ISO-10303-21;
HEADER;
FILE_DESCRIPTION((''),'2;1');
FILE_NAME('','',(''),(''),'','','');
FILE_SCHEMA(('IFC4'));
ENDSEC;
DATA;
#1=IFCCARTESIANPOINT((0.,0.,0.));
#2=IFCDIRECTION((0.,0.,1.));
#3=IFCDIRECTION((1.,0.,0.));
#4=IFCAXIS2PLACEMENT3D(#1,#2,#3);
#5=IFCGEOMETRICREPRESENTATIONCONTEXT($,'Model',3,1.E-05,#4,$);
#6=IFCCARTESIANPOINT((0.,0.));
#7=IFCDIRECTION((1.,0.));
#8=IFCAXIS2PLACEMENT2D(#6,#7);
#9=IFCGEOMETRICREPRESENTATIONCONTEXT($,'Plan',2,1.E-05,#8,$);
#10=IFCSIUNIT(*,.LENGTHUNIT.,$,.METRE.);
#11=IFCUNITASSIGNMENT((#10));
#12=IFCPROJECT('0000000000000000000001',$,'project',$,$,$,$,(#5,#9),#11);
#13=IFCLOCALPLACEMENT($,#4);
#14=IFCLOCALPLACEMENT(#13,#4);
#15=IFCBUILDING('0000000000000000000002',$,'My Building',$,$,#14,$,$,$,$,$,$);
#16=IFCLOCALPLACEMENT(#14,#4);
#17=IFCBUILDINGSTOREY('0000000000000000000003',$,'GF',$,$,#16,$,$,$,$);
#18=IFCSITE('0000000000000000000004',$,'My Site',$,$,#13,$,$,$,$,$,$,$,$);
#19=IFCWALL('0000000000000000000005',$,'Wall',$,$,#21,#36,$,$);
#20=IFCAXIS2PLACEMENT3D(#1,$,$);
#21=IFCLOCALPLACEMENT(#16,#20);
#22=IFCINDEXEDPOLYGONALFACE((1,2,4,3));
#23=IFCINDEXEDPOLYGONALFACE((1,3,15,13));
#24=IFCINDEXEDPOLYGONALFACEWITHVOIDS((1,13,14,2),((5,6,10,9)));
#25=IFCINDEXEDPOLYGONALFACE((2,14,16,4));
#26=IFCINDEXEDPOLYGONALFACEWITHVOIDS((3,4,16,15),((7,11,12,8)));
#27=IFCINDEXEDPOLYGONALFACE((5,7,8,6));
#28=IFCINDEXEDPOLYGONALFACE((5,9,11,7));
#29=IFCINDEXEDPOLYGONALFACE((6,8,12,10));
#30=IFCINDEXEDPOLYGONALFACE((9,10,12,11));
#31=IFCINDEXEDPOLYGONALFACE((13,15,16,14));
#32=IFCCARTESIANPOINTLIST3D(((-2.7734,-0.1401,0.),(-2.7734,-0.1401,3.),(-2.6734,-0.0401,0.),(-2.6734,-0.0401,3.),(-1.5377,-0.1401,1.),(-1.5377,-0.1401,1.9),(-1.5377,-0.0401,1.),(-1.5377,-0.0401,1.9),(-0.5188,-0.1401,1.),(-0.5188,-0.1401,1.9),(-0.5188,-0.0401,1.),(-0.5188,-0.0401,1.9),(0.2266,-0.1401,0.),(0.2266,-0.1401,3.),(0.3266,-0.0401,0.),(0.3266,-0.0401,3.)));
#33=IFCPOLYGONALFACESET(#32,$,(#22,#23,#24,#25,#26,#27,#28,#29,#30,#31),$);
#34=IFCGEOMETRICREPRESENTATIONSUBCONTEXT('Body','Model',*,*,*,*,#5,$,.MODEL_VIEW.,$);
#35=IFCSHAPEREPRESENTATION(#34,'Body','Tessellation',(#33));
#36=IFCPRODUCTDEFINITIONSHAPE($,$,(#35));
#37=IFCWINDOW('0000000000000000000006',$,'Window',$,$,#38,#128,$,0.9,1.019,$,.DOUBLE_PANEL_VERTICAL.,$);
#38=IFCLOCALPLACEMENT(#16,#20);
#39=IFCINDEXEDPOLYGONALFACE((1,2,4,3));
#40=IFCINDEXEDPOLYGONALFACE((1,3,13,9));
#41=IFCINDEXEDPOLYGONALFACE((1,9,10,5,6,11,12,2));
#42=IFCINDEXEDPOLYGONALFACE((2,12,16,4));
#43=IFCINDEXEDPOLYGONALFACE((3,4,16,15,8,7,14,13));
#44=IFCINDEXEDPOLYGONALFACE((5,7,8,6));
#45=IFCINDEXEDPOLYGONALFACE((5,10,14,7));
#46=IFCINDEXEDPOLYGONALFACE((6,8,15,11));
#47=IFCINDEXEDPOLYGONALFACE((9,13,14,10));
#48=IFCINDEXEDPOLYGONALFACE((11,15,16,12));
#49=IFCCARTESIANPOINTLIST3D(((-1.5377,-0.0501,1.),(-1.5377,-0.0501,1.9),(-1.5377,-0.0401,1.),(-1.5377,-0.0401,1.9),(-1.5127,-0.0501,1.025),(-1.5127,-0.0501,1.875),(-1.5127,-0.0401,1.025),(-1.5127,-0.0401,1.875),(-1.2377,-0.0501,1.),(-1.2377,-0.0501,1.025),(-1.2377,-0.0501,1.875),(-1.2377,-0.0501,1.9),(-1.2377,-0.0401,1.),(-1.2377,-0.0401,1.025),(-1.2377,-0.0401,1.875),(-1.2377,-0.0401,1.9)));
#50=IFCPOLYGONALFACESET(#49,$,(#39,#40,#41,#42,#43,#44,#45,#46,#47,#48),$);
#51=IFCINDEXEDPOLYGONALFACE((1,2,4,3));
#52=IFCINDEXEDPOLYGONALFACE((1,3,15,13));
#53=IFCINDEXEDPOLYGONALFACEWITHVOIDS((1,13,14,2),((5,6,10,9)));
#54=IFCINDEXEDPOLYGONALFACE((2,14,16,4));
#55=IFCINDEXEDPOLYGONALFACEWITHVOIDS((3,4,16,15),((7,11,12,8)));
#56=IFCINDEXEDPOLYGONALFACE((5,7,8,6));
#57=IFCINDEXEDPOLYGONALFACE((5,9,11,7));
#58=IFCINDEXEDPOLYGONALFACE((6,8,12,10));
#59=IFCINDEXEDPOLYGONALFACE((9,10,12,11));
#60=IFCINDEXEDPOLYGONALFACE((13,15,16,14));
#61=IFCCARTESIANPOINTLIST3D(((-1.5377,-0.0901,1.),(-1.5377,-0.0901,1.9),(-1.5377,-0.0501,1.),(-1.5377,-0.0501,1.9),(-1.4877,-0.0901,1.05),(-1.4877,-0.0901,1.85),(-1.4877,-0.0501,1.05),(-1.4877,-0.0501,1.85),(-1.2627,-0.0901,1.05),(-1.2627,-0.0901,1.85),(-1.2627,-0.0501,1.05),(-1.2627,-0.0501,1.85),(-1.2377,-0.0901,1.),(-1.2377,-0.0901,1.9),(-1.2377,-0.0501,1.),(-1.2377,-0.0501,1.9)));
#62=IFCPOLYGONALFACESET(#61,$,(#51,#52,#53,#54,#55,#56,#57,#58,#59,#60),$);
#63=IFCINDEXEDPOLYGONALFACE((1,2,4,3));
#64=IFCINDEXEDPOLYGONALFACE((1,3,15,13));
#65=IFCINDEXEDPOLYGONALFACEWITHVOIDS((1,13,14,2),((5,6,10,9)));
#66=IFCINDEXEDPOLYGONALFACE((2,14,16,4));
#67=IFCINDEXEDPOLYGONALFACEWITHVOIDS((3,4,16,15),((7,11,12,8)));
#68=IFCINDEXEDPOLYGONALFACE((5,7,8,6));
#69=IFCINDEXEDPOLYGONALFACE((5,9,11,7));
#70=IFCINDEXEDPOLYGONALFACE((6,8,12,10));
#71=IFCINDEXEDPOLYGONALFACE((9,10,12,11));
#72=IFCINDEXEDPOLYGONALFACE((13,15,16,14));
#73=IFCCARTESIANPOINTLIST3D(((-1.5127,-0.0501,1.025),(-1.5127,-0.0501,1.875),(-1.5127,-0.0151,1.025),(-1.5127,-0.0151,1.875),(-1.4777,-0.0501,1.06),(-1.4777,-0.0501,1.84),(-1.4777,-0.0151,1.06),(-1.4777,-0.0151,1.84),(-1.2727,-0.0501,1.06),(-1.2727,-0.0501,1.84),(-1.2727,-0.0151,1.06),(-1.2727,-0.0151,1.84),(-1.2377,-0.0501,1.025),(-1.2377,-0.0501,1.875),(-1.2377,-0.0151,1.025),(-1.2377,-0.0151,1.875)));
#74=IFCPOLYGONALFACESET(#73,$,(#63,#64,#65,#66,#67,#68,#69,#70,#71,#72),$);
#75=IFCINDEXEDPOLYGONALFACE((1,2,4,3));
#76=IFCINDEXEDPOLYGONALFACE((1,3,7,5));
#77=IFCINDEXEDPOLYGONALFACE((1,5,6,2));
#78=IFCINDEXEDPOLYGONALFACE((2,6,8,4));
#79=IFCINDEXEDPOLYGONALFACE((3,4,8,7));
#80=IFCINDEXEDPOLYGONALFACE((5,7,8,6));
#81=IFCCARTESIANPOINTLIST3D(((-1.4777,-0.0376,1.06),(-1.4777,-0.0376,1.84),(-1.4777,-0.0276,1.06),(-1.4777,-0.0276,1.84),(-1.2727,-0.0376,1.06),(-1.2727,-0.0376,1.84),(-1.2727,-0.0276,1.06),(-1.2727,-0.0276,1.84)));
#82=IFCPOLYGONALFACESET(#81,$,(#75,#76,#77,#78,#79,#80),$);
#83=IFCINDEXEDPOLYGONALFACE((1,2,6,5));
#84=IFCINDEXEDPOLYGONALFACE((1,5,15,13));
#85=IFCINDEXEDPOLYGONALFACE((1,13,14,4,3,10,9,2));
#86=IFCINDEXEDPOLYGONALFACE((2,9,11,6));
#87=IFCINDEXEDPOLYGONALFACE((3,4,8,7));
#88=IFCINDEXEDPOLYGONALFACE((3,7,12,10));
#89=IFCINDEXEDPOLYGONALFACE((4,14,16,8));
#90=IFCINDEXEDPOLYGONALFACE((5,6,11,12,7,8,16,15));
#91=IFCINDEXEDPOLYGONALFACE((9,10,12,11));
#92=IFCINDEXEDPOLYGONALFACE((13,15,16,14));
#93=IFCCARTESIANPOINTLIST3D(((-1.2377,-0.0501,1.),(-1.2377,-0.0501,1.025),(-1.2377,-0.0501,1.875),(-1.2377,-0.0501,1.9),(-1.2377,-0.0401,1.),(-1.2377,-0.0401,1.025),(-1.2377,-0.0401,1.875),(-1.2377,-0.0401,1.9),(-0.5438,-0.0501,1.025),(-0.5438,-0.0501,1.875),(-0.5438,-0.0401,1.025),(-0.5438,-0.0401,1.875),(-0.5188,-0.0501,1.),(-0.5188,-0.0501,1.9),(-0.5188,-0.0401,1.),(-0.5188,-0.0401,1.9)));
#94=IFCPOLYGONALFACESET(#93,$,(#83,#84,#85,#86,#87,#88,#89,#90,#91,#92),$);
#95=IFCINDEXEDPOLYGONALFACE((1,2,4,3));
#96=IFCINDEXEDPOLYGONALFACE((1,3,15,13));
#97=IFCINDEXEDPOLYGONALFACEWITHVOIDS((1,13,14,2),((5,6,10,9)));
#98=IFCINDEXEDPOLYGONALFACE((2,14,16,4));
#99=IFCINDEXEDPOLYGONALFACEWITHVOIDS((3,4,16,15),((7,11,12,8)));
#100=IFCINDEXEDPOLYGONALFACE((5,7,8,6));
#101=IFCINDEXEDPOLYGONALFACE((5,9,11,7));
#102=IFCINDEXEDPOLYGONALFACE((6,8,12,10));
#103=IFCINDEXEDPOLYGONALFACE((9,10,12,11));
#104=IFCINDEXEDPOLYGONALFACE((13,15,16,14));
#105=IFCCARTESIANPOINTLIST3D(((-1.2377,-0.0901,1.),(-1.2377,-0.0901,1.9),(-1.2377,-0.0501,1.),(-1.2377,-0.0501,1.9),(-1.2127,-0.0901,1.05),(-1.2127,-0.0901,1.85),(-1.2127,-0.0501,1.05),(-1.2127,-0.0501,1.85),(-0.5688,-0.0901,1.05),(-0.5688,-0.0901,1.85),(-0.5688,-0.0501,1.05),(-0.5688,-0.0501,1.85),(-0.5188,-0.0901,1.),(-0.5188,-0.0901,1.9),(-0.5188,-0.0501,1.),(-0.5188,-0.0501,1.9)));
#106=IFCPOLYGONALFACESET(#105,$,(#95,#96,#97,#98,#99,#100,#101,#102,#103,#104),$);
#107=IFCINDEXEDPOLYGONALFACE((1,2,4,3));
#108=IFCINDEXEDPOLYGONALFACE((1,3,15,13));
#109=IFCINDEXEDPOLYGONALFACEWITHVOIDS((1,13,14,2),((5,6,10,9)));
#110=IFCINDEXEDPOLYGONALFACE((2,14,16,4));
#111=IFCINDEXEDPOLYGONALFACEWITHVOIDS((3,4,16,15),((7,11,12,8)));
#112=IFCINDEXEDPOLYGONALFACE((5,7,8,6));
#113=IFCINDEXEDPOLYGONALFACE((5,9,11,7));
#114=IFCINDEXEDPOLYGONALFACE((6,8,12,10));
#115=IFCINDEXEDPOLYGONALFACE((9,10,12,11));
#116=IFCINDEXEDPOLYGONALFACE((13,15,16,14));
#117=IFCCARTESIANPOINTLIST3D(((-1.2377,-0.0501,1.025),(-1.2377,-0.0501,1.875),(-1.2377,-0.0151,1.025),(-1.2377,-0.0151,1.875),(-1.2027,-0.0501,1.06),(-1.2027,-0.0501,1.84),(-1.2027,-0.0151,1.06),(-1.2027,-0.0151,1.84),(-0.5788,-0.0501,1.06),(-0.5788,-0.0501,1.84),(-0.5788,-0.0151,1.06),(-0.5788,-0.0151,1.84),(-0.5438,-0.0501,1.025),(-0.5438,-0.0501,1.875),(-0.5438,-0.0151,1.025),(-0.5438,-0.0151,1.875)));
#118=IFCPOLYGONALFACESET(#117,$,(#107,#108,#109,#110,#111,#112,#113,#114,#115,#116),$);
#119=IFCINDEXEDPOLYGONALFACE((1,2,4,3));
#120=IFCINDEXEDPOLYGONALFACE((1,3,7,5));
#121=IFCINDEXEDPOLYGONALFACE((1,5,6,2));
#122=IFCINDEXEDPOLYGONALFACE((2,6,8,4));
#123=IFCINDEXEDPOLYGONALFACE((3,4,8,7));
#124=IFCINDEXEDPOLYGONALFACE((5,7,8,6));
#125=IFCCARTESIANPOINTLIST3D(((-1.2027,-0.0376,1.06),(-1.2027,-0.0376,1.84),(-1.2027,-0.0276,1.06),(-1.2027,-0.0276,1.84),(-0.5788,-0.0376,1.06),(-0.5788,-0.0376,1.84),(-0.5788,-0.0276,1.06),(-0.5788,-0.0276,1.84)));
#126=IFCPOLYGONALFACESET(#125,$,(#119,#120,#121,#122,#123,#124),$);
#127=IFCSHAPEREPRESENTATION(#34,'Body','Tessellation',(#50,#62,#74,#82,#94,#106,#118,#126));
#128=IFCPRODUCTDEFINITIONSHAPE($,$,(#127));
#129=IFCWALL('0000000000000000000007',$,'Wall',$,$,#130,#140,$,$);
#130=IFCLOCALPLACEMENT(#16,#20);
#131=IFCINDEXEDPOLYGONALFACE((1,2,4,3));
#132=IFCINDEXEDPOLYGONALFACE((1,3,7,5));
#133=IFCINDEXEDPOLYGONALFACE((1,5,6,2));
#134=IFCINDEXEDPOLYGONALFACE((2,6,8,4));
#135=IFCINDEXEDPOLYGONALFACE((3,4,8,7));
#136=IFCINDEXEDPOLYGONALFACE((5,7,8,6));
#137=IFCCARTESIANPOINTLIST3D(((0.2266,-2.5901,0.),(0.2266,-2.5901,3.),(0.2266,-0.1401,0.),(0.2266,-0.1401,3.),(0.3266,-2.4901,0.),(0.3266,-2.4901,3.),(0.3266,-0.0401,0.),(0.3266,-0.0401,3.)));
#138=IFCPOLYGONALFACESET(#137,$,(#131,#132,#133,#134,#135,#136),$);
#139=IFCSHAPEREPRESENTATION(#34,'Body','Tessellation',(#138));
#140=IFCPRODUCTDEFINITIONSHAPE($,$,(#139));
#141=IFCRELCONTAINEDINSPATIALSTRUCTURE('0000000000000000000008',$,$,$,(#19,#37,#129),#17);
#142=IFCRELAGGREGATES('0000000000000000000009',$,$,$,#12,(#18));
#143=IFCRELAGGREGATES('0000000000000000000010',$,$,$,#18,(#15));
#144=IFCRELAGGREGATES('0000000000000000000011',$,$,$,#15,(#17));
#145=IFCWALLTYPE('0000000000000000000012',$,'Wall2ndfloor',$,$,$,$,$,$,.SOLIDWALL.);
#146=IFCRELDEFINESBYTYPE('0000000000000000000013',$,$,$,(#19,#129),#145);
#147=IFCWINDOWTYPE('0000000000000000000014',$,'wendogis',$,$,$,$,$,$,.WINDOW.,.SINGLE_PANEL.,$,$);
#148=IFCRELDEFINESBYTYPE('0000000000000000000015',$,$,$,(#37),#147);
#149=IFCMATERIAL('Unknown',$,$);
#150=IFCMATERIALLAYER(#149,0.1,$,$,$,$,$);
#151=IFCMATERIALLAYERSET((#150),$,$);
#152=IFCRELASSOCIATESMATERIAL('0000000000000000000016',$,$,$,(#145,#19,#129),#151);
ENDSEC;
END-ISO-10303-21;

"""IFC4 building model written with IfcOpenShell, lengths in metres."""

from ifc_helpers import new_model, entity, si_unit, frame, origin_with_axes, origin_2d_with_axis, place, context, subcontext, project, spatial, line, indexed_curve, outline, extrude, shape, source, transform, mapped, material, layer, layer_set, layer_usage, type_object, type_shapes, element, fill, save


model = new_model("IFC4")

# Units and contexts
model_context = context("Model", 3, precision=1e-05, world=origin_with_axes())
plan_context = context("Plan", 2, precision=1e-05, world=origin_2d_with_axis())
body_context_1 = subcontext(model_context, "Body", "Model", "MODEL_VIEW")
body_context_2 = subcontext(plan_context, "Body", "Plan", "PLAN_VIEW")
ifc_project = project(units=[si_unit("LENGTHUNIT", "METRE")], contexts=[model_context, plan_context])

# Site, building, storey
site_placement = place(None, origin_with_axes())
site = spatial("IfcSite", under=ifc_project, at=site_placement, Name="My Site")
building_placement = place(site_placement, origin_with_axes())
building = spatial("IfcBuilding", under=site, at=building_placement, Name="My Building")
storey_placement = place(building_placement, origin_with_axes())
storey = spatial("IfcBuildingStorey", under=building, at=storey_placement, Name="GF")

# Shared definitions
ifc_material = material(Name="Unknown")

# Shared definitions
ifc_layer_1 = layer(ifc_material, 0.1)
ifc_layer_set_1 = layer_set([ifc_layer_1])
wall_type = type_object("IfcWallType", Name="Wall2ndfloor", PredefinedType="SOLIDWALL", material=ifc_layer_set_1)

# Wall, opening, window
ifc_layer_usage_1 = layer_usage(ifc_layer_set_1, "AXIS2", "POSITIVE", 0.0)
wall_1_placement = place(storey_placement, frame((-2.7734, -0.1401, 0.0), z_axis=(0.0, 0.0, 1.0), x_axis=(1.0, 0.0, 0.0)))
wall_1 = element("IfcWall", 1, at=wall_1_placement, inside=storey, type_object=wall_type, material=ifc_layer_usage_1, Name="Wall", context=body_context_1, shape_type="SweptSolid", body=[
    extrude(outline(indexed_curve([(0.0, 0.0), (0.1, 0.1), (3.1, 0.1), (3.0, 0.0)], segments=[line(1, 2, 3, 4, 1)])), origin_with_axes(), (0.0, 0.0, 1.0), 3.0),
])
shared_shape_1 = source(origin_with_axes(), body_context_1, "Body", "SweptSolid", [
    extrude(outline(indexed_curve([(0.0, 0.0), (1.019, 0.0), (1.019, 0.9), (0.0, 0.9)], segments=[line(1, 2, 3, 4, 1)])), frame((0.0, -0.6, 0.0), z_axis=(0.0, -1.0, 0.0), x_axis=(1.0, 0.0, 0.0)), (0.0, 0.0, -1.0), 1.2),
])
opening_1_placement = place(wall_1_placement, frame((1.2356, 0.0, 1.0), z_axis=(0.0, 0.0, 1.0), x_axis=(1.0, 0.0, 0.0)))
opening_1 = element("IfcOpeningElement", 2, at=opening_1_placement, cuts=wall_1, PredefinedType="OPENING", context=body_context_1, shape_type="MappedRepresentation", body=[
    mapped(shared_shape_1, transform((0.0, 0.0, 0.0), x_axis=(1.0, 0.0, 0.0), y_axis=(0.0, 1.0, 0.0), z_axis=(0.0, 0.0, 1.0), scale=1.0)),
])
window_type_1 = type_object("IfcWindowType", Name="wendogis", PartitioningType="SINGLE_PANEL", PredefinedType="WINDOW")
shared_shape_2 = source(origin_with_axes(), body_context_1, "Body", "SweptSolid", [
    extrude(outline(indexed_curve([(0.3, 0.0), (0.0, 0.0), (0.0, 0.9), (0.3, 0.9), (0.3, 0.875), (0.025, 0.875), (0.025, 0.025), (0.3, 0.025)], segments=[line(1, 2, 3, 4, 5, 6, 7, 8, 1)])), frame((0.0, 0.09, 0.0), z_axis=(0.0, -1.0, 0.0), x_axis=(1.0, 0.0, 0.0)), (0.0, 0.0, -1.0), 0.01),
    extrude(outline(indexed_curve([(0.0, 0.0), (0.3, 0.0), (0.3, 0.9), (0.0, 0.9)], segments=[line(1, 2, 3, 4, 1)]), holes=[indexed_curve([(0.05, 0.05), (0.275, 0.05), (0.275, 0.85), (0.05, 0.85)], segments=[line(1, 2, 3, 4, 1)])]), frame((0.0, 0.05, 0.0), z_axis=(0.0, -1.0, 0.0), x_axis=(1.0, 0.0, 0.0)), (0.0, 0.0, -1.0), 0.04),
    extrude(outline(indexed_curve([(0.0, 0.0), (0.275, 0.0), (0.275, 0.85), (0.0, 0.85)], segments=[line(1, 2, 3, 4, 1)]), holes=[indexed_curve([(0.035, 0.035), (0.24, 0.035), (0.24, 0.815), (0.035, 0.815)], segments=[line(1, 2, 3, 4, 1)])]), frame((0.025, 0.09, 0.025), z_axis=(0.0, -1.0, 0.0), x_axis=(1.0, 0.0, 0.0)), (0.0, 0.0, -1.0), 0.035),
    extrude(outline(indexed_curve([(0.035, 0.035), (0.24, 0.035), (0.24, 0.815), (0.035, 0.815)], segments=[line(1, 2, 3, 4, 1)])), frame((0.025, 0.1025, 0.025), z_axis=(0.0, -1.0, 0.0), x_axis=(1.0, 0.0, 0.0)), (0.0, 0.0, -1.0), 0.01),
    extrude(outline(indexed_curve([(0.0, 0.9), (0.719, 0.9), (0.719, 0.0), (0.0, 0.0), (0.0, 0.025), (0.694, 0.025), (0.694, 0.875), (0.0, 0.875)], segments=[line(1, 2, 3, 4, 5, 6, 7, 8, 1)])), frame((0.3, 0.09, 0.0), z_axis=(0.0, -1.0, 0.0), x_axis=(1.0, 0.0, 0.0)), (0.0, 0.0, -1.0), 0.01),
    extrude(outline(indexed_curve([(0.0, 0.0), (0.719, 0.0), (0.719, 0.9), (0.0, 0.9)], segments=[line(1, 2, 3, 4, 1)]), holes=[indexed_curve([(0.025, 0.05), (0.669, 0.05), (0.669, 0.85), (0.025, 0.85)], segments=[line(1, 2, 3, 4, 1)])]), frame((0.3, 0.05, 0.0), z_axis=(0.0, -1.0, 0.0), x_axis=(1.0, 0.0, 0.0)), (0.0, 0.0, -1.0), 0.04),
    extrude(outline(indexed_curve([(0.0, 0.0), (0.694, 0.0), (0.694, 0.85), (0.0, 0.85)], segments=[line(1, 2, 3, 4, 1)]), holes=[indexed_curve([(0.035, 0.035), (0.659, 0.035), (0.659, 0.815), (0.035, 0.815)], segments=[line(1, 2, 3, 4, 1)])]), frame((0.3, 0.09, 0.025), z_axis=(0.0, -1.0, 0.0), x_axis=(1.0, 0.0, 0.0)), (0.0, 0.0, -1.0), 0.035),
    extrude(outline(indexed_curve([(0.035, 0.035), (0.659, 0.035), (0.659, 0.815), (0.035, 0.815)], segments=[line(1, 2, 3, 4, 1)])), frame((0.3, 0.1025, 0.025), z_axis=(0.0, -1.0, 0.0), x_axis=(1.0, 0.0, 0.0)), (0.0, 0.0, -1.0), 0.01),
])
shared_shape_3 = source(origin_with_axes(), body_context_2, "Body", "Curve2D", [
    entity("IfcIndexedPolyCurve", entity("IfcCartesianPointList2D", [[0.05, 0.05], [0.275, 0.05]])),
    entity("IfcIndexedPolyCurve", entity("IfcCartesianPointList2D", [[0.0, 0.1], [0.025, 0.1], [0.025, 0.09], [0.05, 0.09], [0.05, 0.05], [0.0, 0.05]]), [entity("IfcLineIndex", [1, 2, 3, 4, 5, 6, 1])]),
    entity("IfcIndexedPolyCurve", entity("IfcCartesianPointList2D", [[0.3, 0.1], [0.3, 0.1], [0.3, 0.09], [0.275, 0.09], [0.275, 0.05], [0.3, 0.05]])),
    entity("IfcIndexedPolyCurve", entity("IfcCartesianPointList2D", [[0.025, 0.09], [0.06, 0.09], [0.06, 0.125], [0.025, 0.125]]), [entity("IfcLineIndex", [1, 2, 3, 4, 1])]),
    entity("IfcIndexedPolyCurve", entity("IfcCartesianPointList2D", [[0.3, 0.09], [0.265, 0.09], [0.265, 0.125], [0.3, 0.125]]), [entity("IfcLineIndex", [1, 2, 3, 4, 1])]),
    entity("IfcIndexedPolyCurve", entity("IfcCartesianPointList2D", [[0.06, 0.09], [0.265, 0.09]])),
    entity("IfcIndexedPolyCurve", entity("IfcCartesianPointList2D", [[0.06, 0.125], [0.265, 0.125]])),
    entity("IfcIndexedPolyCurve", entity("IfcCartesianPointList2D", [[0.06, 0.1075], [0.265, 0.1075]])),
    entity("IfcIndexedPolyCurve", entity("IfcCartesianPointList2D", [[0.325, 0.05], [0.969, 0.05]])),
    entity("IfcIndexedPolyCurve", entity("IfcCartesianPointList2D", [[0.3, 0.1], [0.3, 0.1], [0.3, 0.09], [0.325, 0.09], [0.325, 0.05], [0.3, 0.05]])),
    entity("IfcIndexedPolyCurve", entity("IfcCartesianPointList2D", [[1.019, 0.1], [0.994, 0.1], [0.994, 0.09], [0.969, 0.09], [0.969, 0.05], [1.019, 0.05]]), [entity("IfcLineIndex", [1, 2, 3, 4, 5, 6, 1])]),
    entity("IfcIndexedPolyCurve", entity("IfcCartesianPointList2D", [[0.3, 0.09], [0.335, 0.09], [0.335, 0.125], [0.3, 0.125]]), [entity("IfcLineIndex", [1, 2, 3, 4, 1])]),
    entity("IfcIndexedPolyCurve", entity("IfcCartesianPointList2D", [[0.994, 0.09], [0.959, 0.09], [0.959, 0.125], [0.994, 0.125]]), [entity("IfcLineIndex", [1, 2, 3, 4, 1])]),
    entity("IfcIndexedPolyCurve", entity("IfcCartesianPointList2D", [[0.335, 0.09], [0.959, 0.09]])),
    entity("IfcIndexedPolyCurve", entity("IfcCartesianPointList2D", [[0.335, 0.125], [0.959, 0.125]])),
    entity("IfcIndexedPolyCurve", entity("IfcCartesianPointList2D", [[0.335, 0.1075], [0.959, 0.1075]])),
])
type_shapes(window_type_1, [shared_shape_2, shared_shape_3])
window_1_placement = place(opening_1_placement, frame((0.0, 0.0, 0.0), z_axis=(0.0, 0.0, 1.0), x_axis=(1.0, 0.0, 0.0)))
window_1 = element("IfcWindow", 3, at=window_1_placement, inside=storey, type_object=window_type_1, Name="Window", OverallHeight=0.9, OverallWidth=1.019, PartitioningType="DOUBLE_PANEL_VERTICAL", shapes=[
    shape(body_context_1, "Body", "MappedRepresentation", [mapped(shared_shape_2, transform((0.0, 0.0, 0.0), x_axis=(1.0, 0.0, 0.0), y_axis=(0.0, 1.0, 0.0), z_axis=(0.0, 0.0, 1.0), scale=1.0))]),
    shape(body_context_2, "Body", "MappedRepresentation", [mapped(shared_shape_3, transform((0.0, 0.0, 0.0), x_axis=(1.0, 0.0, 0.0), y_axis=(0.0, 1.0, 0.0), z_axis=(0.0, 0.0, 1.0), scale=1.0))]),
])
fill(opening_1, window_1)

# Wall
ifc_layer_usage_2 = layer_usage(ifc_layer_set_1, "AXIS2", "POSITIVE", 0.0)
wall_2_placement = place(storey_placement, frame((0.2266, -0.1401, 0.0), z_axis=(0.0, 0.0, 1.0), x_axis=(0.0, -1.0, 0.0)))
element("IfcWall", 4, at=wall_2_placement, inside=storey, type_object=wall_type, material=ifc_layer_usage_2, Name="Wall", context=body_context_1, shape_type="SweptSolid", body=[
    extrude(outline(indexed_curve([(0.0, 0.0), (-0.1, 0.1), (2.35, 0.1), (2.45, 0.0)], segments=[line(1, 2, 3, 4, 1)])), origin_with_axes(), (0.0, 0.0, 1.0), 3.0),
])

save(model, "model.ifc")
